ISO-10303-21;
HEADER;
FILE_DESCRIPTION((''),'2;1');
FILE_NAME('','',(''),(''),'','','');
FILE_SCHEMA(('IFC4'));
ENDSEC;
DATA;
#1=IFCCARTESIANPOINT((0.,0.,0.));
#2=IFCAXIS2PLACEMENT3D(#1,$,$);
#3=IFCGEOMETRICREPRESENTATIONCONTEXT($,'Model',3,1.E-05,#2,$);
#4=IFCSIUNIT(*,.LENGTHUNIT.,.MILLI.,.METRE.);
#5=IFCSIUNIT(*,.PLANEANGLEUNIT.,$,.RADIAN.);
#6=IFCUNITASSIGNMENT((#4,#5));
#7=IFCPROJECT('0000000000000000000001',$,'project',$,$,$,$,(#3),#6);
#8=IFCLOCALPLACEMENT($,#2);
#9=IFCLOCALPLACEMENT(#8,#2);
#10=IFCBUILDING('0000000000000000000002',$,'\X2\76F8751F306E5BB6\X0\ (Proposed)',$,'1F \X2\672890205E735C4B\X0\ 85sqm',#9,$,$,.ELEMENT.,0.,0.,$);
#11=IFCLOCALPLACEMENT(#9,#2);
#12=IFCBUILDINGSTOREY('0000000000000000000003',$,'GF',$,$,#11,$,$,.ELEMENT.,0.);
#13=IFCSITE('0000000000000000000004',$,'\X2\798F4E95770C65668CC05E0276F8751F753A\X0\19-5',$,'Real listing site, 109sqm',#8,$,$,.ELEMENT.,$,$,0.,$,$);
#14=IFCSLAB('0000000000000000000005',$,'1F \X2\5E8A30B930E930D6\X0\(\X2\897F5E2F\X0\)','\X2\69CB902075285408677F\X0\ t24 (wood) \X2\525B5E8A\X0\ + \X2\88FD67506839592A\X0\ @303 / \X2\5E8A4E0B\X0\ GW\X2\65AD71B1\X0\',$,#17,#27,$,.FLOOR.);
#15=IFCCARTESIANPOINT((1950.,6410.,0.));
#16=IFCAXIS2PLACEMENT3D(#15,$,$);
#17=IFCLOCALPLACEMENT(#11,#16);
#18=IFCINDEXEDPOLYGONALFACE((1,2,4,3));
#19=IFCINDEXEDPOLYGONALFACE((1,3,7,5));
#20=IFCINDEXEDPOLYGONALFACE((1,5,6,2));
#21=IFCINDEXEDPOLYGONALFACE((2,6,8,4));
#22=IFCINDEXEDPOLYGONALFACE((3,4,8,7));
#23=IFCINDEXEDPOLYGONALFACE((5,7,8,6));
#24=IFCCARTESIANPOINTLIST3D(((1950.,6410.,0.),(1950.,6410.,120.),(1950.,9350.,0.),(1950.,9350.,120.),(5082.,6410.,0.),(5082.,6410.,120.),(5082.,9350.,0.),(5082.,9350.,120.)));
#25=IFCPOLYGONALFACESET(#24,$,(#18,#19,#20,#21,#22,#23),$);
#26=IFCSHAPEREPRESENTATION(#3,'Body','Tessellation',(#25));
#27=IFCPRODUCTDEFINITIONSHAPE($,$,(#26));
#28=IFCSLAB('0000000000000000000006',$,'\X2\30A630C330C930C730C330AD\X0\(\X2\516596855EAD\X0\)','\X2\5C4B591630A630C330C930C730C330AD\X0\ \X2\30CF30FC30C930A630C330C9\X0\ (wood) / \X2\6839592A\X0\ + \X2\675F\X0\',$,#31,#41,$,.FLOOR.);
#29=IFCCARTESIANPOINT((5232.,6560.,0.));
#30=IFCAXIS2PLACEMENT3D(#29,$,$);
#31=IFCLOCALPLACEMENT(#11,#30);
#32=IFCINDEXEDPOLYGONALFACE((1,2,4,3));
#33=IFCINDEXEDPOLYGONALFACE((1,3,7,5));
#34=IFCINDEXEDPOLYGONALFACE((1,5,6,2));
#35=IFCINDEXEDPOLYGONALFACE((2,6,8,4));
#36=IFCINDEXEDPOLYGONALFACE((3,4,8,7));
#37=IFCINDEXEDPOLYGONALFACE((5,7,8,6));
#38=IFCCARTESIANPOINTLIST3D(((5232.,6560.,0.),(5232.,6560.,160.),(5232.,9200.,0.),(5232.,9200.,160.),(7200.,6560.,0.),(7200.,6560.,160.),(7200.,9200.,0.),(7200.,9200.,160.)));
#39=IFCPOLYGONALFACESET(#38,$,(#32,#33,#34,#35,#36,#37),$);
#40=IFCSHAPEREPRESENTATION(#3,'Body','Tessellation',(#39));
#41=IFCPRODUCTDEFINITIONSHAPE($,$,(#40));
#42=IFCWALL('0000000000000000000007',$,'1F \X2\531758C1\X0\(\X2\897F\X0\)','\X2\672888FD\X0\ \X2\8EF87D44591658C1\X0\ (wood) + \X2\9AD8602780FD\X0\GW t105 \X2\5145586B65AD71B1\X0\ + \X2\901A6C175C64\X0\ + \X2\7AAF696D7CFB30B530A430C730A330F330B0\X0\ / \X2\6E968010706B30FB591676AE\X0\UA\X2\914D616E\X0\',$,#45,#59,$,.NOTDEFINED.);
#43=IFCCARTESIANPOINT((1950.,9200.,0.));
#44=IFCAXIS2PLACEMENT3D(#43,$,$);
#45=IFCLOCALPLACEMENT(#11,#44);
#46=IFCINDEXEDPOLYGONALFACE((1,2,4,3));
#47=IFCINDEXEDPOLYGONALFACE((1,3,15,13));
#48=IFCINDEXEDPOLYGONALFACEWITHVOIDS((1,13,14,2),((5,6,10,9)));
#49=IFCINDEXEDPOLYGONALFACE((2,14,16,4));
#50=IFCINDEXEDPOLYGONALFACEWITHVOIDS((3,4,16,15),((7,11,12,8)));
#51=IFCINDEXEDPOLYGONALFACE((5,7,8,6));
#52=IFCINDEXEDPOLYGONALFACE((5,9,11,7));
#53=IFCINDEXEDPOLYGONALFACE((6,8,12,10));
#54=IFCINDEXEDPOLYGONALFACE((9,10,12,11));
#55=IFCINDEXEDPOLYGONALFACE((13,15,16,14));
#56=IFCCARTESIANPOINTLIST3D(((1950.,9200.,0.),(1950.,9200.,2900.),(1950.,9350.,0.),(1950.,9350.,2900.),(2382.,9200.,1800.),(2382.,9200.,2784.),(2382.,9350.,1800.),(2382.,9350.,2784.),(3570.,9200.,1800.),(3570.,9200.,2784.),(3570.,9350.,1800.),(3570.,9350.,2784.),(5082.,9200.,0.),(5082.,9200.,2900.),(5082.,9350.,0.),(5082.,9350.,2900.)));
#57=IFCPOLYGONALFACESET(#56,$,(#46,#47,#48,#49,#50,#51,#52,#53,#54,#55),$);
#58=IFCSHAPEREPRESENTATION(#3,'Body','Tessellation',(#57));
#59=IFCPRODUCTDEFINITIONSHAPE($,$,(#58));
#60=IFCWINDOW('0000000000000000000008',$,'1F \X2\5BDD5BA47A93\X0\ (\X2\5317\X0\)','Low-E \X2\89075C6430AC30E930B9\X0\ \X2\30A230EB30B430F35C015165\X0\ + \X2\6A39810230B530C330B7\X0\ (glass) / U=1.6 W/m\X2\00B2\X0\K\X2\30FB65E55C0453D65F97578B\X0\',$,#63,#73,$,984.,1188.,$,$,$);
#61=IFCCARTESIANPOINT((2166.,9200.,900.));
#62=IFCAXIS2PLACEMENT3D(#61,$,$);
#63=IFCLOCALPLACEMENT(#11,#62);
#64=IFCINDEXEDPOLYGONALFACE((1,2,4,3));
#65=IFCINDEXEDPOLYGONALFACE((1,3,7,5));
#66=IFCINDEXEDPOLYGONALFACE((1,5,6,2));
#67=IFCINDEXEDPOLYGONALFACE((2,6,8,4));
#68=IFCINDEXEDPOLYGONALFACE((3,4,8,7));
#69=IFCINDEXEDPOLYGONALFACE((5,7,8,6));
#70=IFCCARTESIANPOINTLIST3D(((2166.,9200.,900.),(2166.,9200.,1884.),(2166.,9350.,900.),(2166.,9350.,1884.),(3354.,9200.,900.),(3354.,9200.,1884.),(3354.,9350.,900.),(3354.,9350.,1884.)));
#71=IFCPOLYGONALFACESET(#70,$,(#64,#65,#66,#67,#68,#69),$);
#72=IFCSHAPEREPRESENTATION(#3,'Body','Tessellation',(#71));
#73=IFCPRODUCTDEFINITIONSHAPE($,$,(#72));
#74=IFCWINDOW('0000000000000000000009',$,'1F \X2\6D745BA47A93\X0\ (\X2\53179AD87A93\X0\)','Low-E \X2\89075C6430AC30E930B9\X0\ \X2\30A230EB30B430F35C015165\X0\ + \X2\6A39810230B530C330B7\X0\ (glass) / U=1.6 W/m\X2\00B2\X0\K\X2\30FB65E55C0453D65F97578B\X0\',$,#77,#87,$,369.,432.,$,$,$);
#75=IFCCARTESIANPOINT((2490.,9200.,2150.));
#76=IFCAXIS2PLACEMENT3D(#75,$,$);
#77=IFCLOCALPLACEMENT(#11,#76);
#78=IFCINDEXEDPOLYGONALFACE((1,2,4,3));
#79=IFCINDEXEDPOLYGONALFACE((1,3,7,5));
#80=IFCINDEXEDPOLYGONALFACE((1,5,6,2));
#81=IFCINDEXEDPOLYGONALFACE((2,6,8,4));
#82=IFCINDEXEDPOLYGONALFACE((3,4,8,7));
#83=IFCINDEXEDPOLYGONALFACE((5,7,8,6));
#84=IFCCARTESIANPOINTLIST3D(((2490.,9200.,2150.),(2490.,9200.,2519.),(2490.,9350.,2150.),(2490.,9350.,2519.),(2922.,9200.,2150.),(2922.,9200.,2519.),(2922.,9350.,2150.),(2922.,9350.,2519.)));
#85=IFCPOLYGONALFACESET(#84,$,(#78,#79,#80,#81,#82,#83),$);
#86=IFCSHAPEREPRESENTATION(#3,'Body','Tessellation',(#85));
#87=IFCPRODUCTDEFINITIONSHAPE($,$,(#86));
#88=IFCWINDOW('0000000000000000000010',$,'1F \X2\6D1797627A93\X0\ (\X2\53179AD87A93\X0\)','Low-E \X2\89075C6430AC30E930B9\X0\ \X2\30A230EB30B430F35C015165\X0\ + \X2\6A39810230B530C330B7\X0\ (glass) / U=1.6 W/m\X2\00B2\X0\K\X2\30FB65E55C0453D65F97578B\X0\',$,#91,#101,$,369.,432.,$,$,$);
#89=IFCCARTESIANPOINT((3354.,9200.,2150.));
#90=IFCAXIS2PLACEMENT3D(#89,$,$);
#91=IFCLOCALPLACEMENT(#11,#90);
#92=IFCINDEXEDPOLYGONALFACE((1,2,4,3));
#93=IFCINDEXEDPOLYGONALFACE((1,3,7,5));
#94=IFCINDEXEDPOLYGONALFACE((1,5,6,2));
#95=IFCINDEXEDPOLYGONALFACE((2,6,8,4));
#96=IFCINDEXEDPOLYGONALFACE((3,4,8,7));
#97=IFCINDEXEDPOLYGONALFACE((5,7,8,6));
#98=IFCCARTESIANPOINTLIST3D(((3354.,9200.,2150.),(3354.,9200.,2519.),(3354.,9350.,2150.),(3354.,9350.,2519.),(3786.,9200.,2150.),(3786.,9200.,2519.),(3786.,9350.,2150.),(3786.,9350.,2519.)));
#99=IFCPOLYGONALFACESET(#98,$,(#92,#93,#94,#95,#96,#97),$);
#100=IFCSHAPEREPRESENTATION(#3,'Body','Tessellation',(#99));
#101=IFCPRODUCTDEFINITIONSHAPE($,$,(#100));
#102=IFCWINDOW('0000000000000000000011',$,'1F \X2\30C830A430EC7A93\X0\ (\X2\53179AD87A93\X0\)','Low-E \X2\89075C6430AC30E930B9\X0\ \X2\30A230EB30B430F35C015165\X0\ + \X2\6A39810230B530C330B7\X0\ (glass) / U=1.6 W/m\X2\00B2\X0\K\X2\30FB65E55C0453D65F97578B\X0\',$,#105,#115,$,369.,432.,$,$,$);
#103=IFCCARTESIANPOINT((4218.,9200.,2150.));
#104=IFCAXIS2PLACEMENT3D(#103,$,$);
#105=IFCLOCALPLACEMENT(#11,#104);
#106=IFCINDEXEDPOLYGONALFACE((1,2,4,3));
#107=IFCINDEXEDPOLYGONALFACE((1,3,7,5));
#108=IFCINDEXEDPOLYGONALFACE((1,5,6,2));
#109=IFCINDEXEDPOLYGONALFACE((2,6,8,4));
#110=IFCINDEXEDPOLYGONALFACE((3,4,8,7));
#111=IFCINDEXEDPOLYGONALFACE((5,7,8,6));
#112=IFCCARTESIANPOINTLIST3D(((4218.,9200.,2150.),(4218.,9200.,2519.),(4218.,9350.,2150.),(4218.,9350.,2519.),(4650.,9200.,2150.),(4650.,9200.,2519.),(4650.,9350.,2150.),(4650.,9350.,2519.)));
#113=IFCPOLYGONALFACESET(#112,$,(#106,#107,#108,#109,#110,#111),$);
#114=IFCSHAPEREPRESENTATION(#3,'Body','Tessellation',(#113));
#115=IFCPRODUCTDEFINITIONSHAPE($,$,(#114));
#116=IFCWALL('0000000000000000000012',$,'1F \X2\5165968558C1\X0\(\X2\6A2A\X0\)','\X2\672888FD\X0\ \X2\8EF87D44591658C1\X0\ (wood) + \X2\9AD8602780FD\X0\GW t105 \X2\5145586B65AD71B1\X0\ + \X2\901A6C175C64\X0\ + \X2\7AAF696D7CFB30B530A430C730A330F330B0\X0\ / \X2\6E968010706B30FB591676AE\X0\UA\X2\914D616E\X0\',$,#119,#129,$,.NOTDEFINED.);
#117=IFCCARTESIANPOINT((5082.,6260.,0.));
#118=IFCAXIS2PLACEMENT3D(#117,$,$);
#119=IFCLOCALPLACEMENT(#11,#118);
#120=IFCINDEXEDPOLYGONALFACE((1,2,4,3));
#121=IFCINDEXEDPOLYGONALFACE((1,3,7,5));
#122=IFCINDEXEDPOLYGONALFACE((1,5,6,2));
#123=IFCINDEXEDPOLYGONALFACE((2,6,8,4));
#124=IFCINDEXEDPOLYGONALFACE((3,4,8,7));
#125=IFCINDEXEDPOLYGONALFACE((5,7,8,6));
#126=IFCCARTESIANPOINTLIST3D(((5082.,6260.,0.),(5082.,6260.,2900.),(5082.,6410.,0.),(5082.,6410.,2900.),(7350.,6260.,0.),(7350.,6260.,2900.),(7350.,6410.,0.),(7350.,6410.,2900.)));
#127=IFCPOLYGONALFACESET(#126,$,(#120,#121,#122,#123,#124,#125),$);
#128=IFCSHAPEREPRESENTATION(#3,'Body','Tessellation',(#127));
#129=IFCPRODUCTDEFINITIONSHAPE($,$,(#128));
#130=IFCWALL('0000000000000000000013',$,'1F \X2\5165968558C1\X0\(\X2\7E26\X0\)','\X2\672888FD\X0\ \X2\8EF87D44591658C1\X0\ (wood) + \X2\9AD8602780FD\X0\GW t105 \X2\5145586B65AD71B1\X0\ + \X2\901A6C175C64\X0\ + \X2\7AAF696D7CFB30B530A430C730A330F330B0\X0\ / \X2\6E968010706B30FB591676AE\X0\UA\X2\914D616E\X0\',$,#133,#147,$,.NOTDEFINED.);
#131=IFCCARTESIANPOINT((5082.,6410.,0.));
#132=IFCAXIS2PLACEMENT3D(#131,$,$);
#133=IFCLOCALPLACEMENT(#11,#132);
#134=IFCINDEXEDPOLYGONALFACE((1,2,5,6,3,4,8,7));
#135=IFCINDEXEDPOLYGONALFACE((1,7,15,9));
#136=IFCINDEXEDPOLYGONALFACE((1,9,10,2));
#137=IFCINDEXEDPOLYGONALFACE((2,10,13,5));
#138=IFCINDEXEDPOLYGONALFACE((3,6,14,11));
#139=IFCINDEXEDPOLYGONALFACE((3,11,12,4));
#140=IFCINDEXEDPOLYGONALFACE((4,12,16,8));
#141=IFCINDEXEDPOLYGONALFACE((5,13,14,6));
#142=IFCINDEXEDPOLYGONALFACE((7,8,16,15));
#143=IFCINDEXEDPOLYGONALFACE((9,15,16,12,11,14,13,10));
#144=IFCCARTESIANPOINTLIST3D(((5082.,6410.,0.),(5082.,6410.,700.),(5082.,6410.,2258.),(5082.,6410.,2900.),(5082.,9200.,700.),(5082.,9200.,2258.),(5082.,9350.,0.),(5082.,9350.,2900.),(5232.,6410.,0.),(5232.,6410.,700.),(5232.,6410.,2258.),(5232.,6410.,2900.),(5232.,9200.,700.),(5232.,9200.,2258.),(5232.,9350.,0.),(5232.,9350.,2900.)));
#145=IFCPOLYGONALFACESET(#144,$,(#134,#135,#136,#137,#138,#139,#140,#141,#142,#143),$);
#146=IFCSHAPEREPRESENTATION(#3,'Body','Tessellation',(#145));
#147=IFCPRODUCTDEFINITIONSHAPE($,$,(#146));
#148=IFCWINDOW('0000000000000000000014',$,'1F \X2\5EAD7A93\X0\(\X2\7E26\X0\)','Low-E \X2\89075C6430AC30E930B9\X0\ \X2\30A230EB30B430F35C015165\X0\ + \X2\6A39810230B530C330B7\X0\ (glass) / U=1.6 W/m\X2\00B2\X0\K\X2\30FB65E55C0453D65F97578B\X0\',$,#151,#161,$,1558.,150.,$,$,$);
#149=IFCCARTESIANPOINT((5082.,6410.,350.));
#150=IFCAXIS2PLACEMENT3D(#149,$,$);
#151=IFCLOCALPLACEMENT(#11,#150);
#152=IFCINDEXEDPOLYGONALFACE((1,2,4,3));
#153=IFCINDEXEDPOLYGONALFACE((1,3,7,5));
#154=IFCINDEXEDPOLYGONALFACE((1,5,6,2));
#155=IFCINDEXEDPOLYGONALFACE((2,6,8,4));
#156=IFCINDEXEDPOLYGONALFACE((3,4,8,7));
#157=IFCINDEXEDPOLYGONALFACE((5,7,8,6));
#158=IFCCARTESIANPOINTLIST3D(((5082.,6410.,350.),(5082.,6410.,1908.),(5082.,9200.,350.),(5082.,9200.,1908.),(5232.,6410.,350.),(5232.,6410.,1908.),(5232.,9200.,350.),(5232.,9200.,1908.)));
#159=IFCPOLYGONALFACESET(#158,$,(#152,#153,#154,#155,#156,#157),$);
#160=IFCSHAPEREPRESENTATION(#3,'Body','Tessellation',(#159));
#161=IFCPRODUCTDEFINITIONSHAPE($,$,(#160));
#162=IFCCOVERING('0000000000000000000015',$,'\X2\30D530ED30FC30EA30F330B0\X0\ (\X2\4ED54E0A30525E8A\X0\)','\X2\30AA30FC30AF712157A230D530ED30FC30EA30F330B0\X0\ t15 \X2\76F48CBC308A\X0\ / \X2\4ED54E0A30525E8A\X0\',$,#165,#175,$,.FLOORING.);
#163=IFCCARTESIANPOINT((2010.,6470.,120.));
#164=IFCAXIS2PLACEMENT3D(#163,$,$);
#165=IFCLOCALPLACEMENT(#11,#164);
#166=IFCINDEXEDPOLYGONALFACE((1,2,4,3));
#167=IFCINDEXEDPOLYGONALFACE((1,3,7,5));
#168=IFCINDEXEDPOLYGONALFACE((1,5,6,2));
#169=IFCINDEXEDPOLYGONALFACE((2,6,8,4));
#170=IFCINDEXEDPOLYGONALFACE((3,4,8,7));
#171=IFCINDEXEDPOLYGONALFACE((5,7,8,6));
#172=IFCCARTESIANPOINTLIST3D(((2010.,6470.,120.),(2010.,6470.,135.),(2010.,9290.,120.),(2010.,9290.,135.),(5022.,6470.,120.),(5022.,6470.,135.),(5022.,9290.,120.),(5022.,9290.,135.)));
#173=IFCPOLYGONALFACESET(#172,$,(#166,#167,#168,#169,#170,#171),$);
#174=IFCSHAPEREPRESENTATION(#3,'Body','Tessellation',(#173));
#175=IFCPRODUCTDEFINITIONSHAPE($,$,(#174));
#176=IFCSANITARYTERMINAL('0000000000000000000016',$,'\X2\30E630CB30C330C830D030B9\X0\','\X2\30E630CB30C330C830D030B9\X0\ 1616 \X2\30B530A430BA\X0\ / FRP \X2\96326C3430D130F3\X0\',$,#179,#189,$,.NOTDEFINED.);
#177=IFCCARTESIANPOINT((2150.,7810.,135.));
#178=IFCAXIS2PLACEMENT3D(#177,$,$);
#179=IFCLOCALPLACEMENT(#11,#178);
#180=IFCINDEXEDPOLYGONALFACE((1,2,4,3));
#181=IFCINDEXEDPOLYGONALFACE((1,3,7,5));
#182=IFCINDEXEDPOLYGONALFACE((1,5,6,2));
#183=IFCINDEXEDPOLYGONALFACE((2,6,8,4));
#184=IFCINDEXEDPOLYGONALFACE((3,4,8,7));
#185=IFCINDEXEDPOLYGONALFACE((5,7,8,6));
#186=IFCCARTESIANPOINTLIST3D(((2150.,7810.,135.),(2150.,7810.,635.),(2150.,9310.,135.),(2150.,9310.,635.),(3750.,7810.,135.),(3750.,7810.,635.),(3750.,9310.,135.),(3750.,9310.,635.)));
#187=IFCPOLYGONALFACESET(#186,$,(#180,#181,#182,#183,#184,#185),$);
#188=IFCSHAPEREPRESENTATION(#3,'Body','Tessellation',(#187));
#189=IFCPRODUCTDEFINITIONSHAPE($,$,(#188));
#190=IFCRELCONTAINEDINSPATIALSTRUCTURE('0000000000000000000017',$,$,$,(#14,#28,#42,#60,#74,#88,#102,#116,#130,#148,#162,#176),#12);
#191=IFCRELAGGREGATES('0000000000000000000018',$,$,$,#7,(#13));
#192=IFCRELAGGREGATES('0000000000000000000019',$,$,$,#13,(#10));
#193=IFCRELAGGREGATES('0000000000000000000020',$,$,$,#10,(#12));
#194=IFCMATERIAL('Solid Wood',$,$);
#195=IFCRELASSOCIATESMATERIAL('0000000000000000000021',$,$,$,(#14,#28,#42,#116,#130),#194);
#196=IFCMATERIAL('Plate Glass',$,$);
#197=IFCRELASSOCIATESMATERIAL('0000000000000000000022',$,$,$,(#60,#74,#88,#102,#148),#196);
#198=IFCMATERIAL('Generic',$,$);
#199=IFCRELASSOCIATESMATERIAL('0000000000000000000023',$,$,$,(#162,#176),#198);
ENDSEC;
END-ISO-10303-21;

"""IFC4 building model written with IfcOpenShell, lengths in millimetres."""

from ifc_helpers import new_model, si_unit, frame, frame_2d, origin, place, context, project, spatial, rectangle, extrude, material, element, fill, save


model = new_model("IFC4")

# Units and contexts
model_context = context("Model", 3, precision=1e-05, world=origin())
ifc_project = project(units=[si_unit("LENGTHUNIT", "METRE", prefix="MILLI"), si_unit("PLANEANGLEUNIT", "RADIAN")], contexts=[model_context])

# Site, building, storey
site_placement = place(None, origin())
site = spatial("IfcSite", under=ifc_project, at=site_placement, Name="福井県敦賀市相生町19-5", ObjectType="Real listing site, 109sqm", CompositionType="ELEMENT", RefElevation=0.0)
building_placement = place(site_placement, origin())
building = spatial("IfcBuilding", under=site, at=building_placement, Name="相生の家 (Proposed)", ObjectType="1F 木造平屋 85sqm", CompositionType="ELEMENT", ElevationOfRefHeight=0.0, ElevationOfTerrain=0.0)
storey_placement = place(building_placement, origin())
storey = spatial("IfcBuildingStorey", under=building, at=storey_placement, Name="GF", CompositionType="ELEMENT", Elevation=0.0)

# Slabs
ifc_material_1 = material(Name="Solid Wood")
slab_1_placement = place(storey_placement, frame((1950.0, 6410.0, 0.0)))
element("IfcSlab", 1, at=slab_1_placement, inside=storey, material=ifc_material_1, Name="1F 床スラブ(西帯)", Description="構造用合板 t24 (wood) 剛床 + 製材根太 @303 / 床下 GW断熱", PredefinedType="FLOOR", context=model_context, shape_type="SweptSolid", body=[
    extrude(rectangle(XDim=3132.0, YDim=2940.0, at=frame_2d((1566.0, 1470.0))), frame((1950.0, 6410.0, 0.0)), (0.0, 0.0, 1.0), 120.0),
])
slab_2_placement = place(storey_placement, frame((5232.0, 6560.0, 0.0)))
element("IfcSlab", 2, at=slab_2_placement, inside=storey, material=ifc_material_1, Name="ウッドデッキ(入隅庭)", Description="屋外ウッドデッキ ハードウッド (wood) / 根太 + 束", PredefinedType="FLOOR", context=model_context, shape_type="SweptSolid", body=[
    extrude(rectangle(XDim=1968.0, YDim=2640.0, at=frame_2d((984.0, 1320.0))), frame((5232.0, 6560.0, 0.0)), (0.0, 0.0, 1.0), 160.0),
])

# Wall, openings, windows
wall_1_placement = place(storey_placement, frame((1950.0, 9200.0, 0.0)))
wall_1 = element("IfcWall", 3, at=wall_1_placement, inside=storey, material=ifc_material_1, Name="1F 北壁(西)", Description="木製 軸組外壁 (wood) + 高性能GW t105 充填断熱 + 通気層 + 窯業系サイディング / 準耐火・外皮UA配慮", PredefinedType="NOTDEFINED", context=model_context, shape_type="SweptSolid", body=[
    extrude(rectangle(XDim=3132.0, YDim=150.0, at=frame_2d((1566.0, 75.0))), frame((1950.0, 9200.0, 0.0)), (0.0, 0.0, 1.0), 2900.0),
])
opening_1_placement = place(storey_placement, frame((2166.0, 9200.0, 900.0)))
opening_1 = element("IfcOpeningElement", 4, at=opening_1_placement, cuts=wall_1, PredefinedType="NOTDEFINED", context=model_context, shape_type="SweptSolid", body=[
    extrude(rectangle(XDim=1188.0, YDim=150.0, at=frame_2d((594.0, 75.0))), frame((2166.0, 9200.0, 900.0)), (0.0, 0.0, 1.0), 984.0),
])
opening_2_placement = place(storey_placement, frame((2490.0, 9200.0, 2150.0)))
opening_2 = element("IfcOpeningElement", 5, at=opening_2_placement, cuts=wall_1, PredefinedType="NOTDEFINED", context=model_context, shape_type="SweptSolid", body=[
    extrude(rectangle(XDim=432.0, YDim=150.0, at=frame_2d((216.0, 75.0))), frame((2490.0, 9200.0, 2150.0)), (0.0, 0.0, 1.0), 369.0),
])
opening_3_placement = place(storey_placement, frame((3354.0, 9200.0, 2150.0)))
opening_3 = element("IfcOpeningElement", 6, at=opening_3_placement, cuts=wall_1, PredefinedType="NOTDEFINED", context=model_context, shape_type="SweptSolid", body=[
    extrude(rectangle(XDim=432.0, YDim=150.0, at=frame_2d((216.0, 75.0))), frame((3354.0, 9200.0, 2150.0)), (0.0, 0.0, 1.0), 369.0),
])
opening_4_placement = place(storey_placement, frame((4218.0, 9200.0, 2150.0)))
opening_4 = element("IfcOpeningElement", 7, at=opening_4_placement, cuts=wall_1, PredefinedType="NOTDEFINED", context=model_context, shape_type="SweptSolid", body=[
    extrude(rectangle(XDim=432.0, YDim=150.0, at=frame_2d((216.0, 75.0))), frame((4218.0, 9200.0, 2150.0)), (0.0, 0.0, 1.0), 369.0),
])
ifc_material_2 = material(Name="Plate Glass")
window_1_placement = place(storey_placement, frame((2166.0, 9200.0, 900.0)))
window_1 = element("IfcWindow", 8, at=window_1_placement, inside=storey, material=ifc_material_2, Name="1F 寝室窓 (北)", Description="Low-E 複層ガラス アルゴン封入 + 樹脂サッシ (glass) / U=1.6 W/m²K・日射取得型", OverallHeight=984.0, OverallWidth=1188.0, context=model_context, shape_type="SweptSolid", body=[
    extrude(rectangle(XDim=1188.0, YDim=150.0, at=frame_2d((594.0, 75.0))), frame((2166.0, 9200.0, 900.0)), (0.0, 0.0, 1.0), 984.0),
])
fill(opening_1, window_1)
window_2_placement = place(storey_placement, frame((2490.0, 9200.0, 2150.0)))
window_2 = element("IfcWindow", 9, at=window_2_placement, inside=storey, material=ifc_material_2, Name="1F 浴室窓 (北高窓)", Description="Low-E 複層ガラス アルゴン封入 + 樹脂サッシ (glass) / U=1.6 W/m²K・日射取得型", OverallHeight=369.0, OverallWidth=432.0, context=model_context, shape_type="SweptSolid", body=[
    extrude(rectangle(XDim=432.0, YDim=150.0, at=frame_2d((216.0, 75.0))), frame((2490.0, 9200.0, 2150.0)), (0.0, 0.0, 1.0), 369.0),
])
fill(opening_2, window_2)
window_3_placement = place(storey_placement, frame((3354.0, 9200.0, 2150.0)))
window_3 = element("IfcWindow", 10, at=window_3_placement, inside=storey, material=ifc_material_2, Name="1F 洗面窓 (北高窓)", Description="Low-E 複層ガラス アルゴン封入 + 樹脂サッシ (glass) / U=1.6 W/m²K・日射取得型", OverallHeight=369.0, OverallWidth=432.0, context=model_context, shape_type="SweptSolid", body=[
    extrude(rectangle(XDim=432.0, YDim=150.0, at=frame_2d((216.0, 75.0))), frame((3354.0, 9200.0, 2150.0)), (0.0, 0.0, 1.0), 369.0),
])
fill(opening_3, window_3)
window_4_placement = place(storey_placement, frame((4218.0, 9200.0, 2150.0)))
window_4 = element("IfcWindow", 11, at=window_4_placement, inside=storey, material=ifc_material_2, Name="1F トイレ窓 (北高窓)", Description="Low-E 複層ガラス アルゴン封入 + 樹脂サッシ (glass) / U=1.6 W/m²K・日射取得型", OverallHeight=369.0, OverallWidth=432.0, context=model_context, shape_type="SweptSolid", body=[
    extrude(rectangle(XDim=432.0, YDim=150.0, at=frame_2d((216.0, 75.0))), frame((4218.0, 9200.0, 2150.0)), (0.0, 0.0, 1.0), 369.0),
])
fill(opening_4, window_4)

# Wall
wall_2_placement = place(storey_placement, frame((5082.0, 6260.0, 0.0)))
element("IfcWall", 12, at=wall_2_placement, inside=storey, material=ifc_material_1, Name="1F 入隅壁(横)", Description="木製 軸組外壁 (wood) + 高性能GW t105 充填断熱 + 通気層 + 窯業系サイディング / 準耐火・外皮UA配慮", PredefinedType="NOTDEFINED", context=model_context, shape_type="SweptSolid", body=[
    extrude(rectangle(XDim=2268.0, YDim=150.0, at=frame_2d((1134.0, 75.0))), frame((5082.0, 6260.0, 0.0)), (0.0, 0.0, 1.0), 2900.0),
])

# Wall, opening, window
wall_3_placement = place(storey_placement, frame((5082.0, 6410.0, 0.0)))
wall_3 = element("IfcWall", 13, at=wall_3_placement, inside=storey, material=ifc_material_1, Name="1F 入隅壁(縦)", Description="木製 軸組外壁 (wood) + 高性能GW t105 充填断熱 + 通気層 + 窯業系サイディング / 準耐火・外皮UA配慮", PredefinedType="NOTDEFINED", context=model_context, shape_type="SweptSolid", body=[
    extrude(rectangle(XDim=150.0, YDim=2940.0, at=frame_2d((75.0, 1470.0))), frame((5082.0, 6410.0, 0.0)), (0.0, 0.0, 1.0), 2900.0),
])
opening_5_placement = place(storey_placement, frame((5082.0, 6410.0, 350.0)))
opening_5 = element("IfcOpeningElement", 14, at=opening_5_placement, cuts=wall_3, PredefinedType="NOTDEFINED", context=model_context, shape_type="SweptSolid", body=[
    extrude(rectangle(XDim=150.0, YDim=2790.0, at=frame_2d((75.0, 1395.0))), frame((5082.0, 6410.0, 350.0)), (0.0, 0.0, 1.0), 1558.0),
])
window_5_placement = place(storey_placement, frame((5082.0, 6410.0, 350.0)))
window_5 = element("IfcWindow", 15, at=window_5_placement, inside=storey, material=ifc_material_2, Name="1F 庭窓(縦)", Description="Low-E 複層ガラス アルゴン封入 + 樹脂サッシ (glass) / U=1.6 W/m²K・日射取得型", OverallHeight=1558.0, OverallWidth=150.0, context=model_context, shape_type="SweptSolid", body=[
    extrude(rectangle(XDim=150.0, YDim=2790.0, at=frame_2d((75.0, 1395.0))), frame((5082.0, 6410.0, 350.0)), (0.0, 0.0, 1.0), 1558.0),
])
fill(opening_5, window_5)

# Covering
ifc_material_3 = material(Name="Generic")
covering_placement = place(storey_placement, frame((2010.0, 6470.0, 120.0)))
element("IfcCovering", 16, at=covering_placement, inside=storey, material=ifc_material_3, Name="フローリング (仕上げ床)", Description="オーク無垢フローリング t15 直貼り / 仕上げ床", PredefinedType="FLOORING", context=model_context, shape_type="SweptSolid", body=[
    extrude(rectangle(XDim=3012.0, YDim=2820.0, at=frame_2d((1506.0, 1410.0))), frame((2010.0, 6470.0, 120.0)), (0.0, 0.0, 1.0), 15.0),
])

# Sanitary terminal
sanitary_terminal_1_placement = place(storey_placement, frame((2150.0, 7810.0, 135.0)))
element("IfcSanitaryTerminal", 17, at=sanitary_terminal_1_placement, inside=storey, material=ifc_material_3, Name="ユニットバス", Description="ユニットバス 1616 サイズ / FRP 防水パン", PredefinedType="NOTDEFINED", context=model_context, shape_type="SweptSolid", body=[
    extrude(rectangle(XDim=1600.0, YDim=1500.0, at=frame_2d((800.0, 750.0))), frame((2150.0, 7810.0, 135.0)), (0.0, 0.0, 1.0), 500.0),
])

save(model, "model.ifc")
